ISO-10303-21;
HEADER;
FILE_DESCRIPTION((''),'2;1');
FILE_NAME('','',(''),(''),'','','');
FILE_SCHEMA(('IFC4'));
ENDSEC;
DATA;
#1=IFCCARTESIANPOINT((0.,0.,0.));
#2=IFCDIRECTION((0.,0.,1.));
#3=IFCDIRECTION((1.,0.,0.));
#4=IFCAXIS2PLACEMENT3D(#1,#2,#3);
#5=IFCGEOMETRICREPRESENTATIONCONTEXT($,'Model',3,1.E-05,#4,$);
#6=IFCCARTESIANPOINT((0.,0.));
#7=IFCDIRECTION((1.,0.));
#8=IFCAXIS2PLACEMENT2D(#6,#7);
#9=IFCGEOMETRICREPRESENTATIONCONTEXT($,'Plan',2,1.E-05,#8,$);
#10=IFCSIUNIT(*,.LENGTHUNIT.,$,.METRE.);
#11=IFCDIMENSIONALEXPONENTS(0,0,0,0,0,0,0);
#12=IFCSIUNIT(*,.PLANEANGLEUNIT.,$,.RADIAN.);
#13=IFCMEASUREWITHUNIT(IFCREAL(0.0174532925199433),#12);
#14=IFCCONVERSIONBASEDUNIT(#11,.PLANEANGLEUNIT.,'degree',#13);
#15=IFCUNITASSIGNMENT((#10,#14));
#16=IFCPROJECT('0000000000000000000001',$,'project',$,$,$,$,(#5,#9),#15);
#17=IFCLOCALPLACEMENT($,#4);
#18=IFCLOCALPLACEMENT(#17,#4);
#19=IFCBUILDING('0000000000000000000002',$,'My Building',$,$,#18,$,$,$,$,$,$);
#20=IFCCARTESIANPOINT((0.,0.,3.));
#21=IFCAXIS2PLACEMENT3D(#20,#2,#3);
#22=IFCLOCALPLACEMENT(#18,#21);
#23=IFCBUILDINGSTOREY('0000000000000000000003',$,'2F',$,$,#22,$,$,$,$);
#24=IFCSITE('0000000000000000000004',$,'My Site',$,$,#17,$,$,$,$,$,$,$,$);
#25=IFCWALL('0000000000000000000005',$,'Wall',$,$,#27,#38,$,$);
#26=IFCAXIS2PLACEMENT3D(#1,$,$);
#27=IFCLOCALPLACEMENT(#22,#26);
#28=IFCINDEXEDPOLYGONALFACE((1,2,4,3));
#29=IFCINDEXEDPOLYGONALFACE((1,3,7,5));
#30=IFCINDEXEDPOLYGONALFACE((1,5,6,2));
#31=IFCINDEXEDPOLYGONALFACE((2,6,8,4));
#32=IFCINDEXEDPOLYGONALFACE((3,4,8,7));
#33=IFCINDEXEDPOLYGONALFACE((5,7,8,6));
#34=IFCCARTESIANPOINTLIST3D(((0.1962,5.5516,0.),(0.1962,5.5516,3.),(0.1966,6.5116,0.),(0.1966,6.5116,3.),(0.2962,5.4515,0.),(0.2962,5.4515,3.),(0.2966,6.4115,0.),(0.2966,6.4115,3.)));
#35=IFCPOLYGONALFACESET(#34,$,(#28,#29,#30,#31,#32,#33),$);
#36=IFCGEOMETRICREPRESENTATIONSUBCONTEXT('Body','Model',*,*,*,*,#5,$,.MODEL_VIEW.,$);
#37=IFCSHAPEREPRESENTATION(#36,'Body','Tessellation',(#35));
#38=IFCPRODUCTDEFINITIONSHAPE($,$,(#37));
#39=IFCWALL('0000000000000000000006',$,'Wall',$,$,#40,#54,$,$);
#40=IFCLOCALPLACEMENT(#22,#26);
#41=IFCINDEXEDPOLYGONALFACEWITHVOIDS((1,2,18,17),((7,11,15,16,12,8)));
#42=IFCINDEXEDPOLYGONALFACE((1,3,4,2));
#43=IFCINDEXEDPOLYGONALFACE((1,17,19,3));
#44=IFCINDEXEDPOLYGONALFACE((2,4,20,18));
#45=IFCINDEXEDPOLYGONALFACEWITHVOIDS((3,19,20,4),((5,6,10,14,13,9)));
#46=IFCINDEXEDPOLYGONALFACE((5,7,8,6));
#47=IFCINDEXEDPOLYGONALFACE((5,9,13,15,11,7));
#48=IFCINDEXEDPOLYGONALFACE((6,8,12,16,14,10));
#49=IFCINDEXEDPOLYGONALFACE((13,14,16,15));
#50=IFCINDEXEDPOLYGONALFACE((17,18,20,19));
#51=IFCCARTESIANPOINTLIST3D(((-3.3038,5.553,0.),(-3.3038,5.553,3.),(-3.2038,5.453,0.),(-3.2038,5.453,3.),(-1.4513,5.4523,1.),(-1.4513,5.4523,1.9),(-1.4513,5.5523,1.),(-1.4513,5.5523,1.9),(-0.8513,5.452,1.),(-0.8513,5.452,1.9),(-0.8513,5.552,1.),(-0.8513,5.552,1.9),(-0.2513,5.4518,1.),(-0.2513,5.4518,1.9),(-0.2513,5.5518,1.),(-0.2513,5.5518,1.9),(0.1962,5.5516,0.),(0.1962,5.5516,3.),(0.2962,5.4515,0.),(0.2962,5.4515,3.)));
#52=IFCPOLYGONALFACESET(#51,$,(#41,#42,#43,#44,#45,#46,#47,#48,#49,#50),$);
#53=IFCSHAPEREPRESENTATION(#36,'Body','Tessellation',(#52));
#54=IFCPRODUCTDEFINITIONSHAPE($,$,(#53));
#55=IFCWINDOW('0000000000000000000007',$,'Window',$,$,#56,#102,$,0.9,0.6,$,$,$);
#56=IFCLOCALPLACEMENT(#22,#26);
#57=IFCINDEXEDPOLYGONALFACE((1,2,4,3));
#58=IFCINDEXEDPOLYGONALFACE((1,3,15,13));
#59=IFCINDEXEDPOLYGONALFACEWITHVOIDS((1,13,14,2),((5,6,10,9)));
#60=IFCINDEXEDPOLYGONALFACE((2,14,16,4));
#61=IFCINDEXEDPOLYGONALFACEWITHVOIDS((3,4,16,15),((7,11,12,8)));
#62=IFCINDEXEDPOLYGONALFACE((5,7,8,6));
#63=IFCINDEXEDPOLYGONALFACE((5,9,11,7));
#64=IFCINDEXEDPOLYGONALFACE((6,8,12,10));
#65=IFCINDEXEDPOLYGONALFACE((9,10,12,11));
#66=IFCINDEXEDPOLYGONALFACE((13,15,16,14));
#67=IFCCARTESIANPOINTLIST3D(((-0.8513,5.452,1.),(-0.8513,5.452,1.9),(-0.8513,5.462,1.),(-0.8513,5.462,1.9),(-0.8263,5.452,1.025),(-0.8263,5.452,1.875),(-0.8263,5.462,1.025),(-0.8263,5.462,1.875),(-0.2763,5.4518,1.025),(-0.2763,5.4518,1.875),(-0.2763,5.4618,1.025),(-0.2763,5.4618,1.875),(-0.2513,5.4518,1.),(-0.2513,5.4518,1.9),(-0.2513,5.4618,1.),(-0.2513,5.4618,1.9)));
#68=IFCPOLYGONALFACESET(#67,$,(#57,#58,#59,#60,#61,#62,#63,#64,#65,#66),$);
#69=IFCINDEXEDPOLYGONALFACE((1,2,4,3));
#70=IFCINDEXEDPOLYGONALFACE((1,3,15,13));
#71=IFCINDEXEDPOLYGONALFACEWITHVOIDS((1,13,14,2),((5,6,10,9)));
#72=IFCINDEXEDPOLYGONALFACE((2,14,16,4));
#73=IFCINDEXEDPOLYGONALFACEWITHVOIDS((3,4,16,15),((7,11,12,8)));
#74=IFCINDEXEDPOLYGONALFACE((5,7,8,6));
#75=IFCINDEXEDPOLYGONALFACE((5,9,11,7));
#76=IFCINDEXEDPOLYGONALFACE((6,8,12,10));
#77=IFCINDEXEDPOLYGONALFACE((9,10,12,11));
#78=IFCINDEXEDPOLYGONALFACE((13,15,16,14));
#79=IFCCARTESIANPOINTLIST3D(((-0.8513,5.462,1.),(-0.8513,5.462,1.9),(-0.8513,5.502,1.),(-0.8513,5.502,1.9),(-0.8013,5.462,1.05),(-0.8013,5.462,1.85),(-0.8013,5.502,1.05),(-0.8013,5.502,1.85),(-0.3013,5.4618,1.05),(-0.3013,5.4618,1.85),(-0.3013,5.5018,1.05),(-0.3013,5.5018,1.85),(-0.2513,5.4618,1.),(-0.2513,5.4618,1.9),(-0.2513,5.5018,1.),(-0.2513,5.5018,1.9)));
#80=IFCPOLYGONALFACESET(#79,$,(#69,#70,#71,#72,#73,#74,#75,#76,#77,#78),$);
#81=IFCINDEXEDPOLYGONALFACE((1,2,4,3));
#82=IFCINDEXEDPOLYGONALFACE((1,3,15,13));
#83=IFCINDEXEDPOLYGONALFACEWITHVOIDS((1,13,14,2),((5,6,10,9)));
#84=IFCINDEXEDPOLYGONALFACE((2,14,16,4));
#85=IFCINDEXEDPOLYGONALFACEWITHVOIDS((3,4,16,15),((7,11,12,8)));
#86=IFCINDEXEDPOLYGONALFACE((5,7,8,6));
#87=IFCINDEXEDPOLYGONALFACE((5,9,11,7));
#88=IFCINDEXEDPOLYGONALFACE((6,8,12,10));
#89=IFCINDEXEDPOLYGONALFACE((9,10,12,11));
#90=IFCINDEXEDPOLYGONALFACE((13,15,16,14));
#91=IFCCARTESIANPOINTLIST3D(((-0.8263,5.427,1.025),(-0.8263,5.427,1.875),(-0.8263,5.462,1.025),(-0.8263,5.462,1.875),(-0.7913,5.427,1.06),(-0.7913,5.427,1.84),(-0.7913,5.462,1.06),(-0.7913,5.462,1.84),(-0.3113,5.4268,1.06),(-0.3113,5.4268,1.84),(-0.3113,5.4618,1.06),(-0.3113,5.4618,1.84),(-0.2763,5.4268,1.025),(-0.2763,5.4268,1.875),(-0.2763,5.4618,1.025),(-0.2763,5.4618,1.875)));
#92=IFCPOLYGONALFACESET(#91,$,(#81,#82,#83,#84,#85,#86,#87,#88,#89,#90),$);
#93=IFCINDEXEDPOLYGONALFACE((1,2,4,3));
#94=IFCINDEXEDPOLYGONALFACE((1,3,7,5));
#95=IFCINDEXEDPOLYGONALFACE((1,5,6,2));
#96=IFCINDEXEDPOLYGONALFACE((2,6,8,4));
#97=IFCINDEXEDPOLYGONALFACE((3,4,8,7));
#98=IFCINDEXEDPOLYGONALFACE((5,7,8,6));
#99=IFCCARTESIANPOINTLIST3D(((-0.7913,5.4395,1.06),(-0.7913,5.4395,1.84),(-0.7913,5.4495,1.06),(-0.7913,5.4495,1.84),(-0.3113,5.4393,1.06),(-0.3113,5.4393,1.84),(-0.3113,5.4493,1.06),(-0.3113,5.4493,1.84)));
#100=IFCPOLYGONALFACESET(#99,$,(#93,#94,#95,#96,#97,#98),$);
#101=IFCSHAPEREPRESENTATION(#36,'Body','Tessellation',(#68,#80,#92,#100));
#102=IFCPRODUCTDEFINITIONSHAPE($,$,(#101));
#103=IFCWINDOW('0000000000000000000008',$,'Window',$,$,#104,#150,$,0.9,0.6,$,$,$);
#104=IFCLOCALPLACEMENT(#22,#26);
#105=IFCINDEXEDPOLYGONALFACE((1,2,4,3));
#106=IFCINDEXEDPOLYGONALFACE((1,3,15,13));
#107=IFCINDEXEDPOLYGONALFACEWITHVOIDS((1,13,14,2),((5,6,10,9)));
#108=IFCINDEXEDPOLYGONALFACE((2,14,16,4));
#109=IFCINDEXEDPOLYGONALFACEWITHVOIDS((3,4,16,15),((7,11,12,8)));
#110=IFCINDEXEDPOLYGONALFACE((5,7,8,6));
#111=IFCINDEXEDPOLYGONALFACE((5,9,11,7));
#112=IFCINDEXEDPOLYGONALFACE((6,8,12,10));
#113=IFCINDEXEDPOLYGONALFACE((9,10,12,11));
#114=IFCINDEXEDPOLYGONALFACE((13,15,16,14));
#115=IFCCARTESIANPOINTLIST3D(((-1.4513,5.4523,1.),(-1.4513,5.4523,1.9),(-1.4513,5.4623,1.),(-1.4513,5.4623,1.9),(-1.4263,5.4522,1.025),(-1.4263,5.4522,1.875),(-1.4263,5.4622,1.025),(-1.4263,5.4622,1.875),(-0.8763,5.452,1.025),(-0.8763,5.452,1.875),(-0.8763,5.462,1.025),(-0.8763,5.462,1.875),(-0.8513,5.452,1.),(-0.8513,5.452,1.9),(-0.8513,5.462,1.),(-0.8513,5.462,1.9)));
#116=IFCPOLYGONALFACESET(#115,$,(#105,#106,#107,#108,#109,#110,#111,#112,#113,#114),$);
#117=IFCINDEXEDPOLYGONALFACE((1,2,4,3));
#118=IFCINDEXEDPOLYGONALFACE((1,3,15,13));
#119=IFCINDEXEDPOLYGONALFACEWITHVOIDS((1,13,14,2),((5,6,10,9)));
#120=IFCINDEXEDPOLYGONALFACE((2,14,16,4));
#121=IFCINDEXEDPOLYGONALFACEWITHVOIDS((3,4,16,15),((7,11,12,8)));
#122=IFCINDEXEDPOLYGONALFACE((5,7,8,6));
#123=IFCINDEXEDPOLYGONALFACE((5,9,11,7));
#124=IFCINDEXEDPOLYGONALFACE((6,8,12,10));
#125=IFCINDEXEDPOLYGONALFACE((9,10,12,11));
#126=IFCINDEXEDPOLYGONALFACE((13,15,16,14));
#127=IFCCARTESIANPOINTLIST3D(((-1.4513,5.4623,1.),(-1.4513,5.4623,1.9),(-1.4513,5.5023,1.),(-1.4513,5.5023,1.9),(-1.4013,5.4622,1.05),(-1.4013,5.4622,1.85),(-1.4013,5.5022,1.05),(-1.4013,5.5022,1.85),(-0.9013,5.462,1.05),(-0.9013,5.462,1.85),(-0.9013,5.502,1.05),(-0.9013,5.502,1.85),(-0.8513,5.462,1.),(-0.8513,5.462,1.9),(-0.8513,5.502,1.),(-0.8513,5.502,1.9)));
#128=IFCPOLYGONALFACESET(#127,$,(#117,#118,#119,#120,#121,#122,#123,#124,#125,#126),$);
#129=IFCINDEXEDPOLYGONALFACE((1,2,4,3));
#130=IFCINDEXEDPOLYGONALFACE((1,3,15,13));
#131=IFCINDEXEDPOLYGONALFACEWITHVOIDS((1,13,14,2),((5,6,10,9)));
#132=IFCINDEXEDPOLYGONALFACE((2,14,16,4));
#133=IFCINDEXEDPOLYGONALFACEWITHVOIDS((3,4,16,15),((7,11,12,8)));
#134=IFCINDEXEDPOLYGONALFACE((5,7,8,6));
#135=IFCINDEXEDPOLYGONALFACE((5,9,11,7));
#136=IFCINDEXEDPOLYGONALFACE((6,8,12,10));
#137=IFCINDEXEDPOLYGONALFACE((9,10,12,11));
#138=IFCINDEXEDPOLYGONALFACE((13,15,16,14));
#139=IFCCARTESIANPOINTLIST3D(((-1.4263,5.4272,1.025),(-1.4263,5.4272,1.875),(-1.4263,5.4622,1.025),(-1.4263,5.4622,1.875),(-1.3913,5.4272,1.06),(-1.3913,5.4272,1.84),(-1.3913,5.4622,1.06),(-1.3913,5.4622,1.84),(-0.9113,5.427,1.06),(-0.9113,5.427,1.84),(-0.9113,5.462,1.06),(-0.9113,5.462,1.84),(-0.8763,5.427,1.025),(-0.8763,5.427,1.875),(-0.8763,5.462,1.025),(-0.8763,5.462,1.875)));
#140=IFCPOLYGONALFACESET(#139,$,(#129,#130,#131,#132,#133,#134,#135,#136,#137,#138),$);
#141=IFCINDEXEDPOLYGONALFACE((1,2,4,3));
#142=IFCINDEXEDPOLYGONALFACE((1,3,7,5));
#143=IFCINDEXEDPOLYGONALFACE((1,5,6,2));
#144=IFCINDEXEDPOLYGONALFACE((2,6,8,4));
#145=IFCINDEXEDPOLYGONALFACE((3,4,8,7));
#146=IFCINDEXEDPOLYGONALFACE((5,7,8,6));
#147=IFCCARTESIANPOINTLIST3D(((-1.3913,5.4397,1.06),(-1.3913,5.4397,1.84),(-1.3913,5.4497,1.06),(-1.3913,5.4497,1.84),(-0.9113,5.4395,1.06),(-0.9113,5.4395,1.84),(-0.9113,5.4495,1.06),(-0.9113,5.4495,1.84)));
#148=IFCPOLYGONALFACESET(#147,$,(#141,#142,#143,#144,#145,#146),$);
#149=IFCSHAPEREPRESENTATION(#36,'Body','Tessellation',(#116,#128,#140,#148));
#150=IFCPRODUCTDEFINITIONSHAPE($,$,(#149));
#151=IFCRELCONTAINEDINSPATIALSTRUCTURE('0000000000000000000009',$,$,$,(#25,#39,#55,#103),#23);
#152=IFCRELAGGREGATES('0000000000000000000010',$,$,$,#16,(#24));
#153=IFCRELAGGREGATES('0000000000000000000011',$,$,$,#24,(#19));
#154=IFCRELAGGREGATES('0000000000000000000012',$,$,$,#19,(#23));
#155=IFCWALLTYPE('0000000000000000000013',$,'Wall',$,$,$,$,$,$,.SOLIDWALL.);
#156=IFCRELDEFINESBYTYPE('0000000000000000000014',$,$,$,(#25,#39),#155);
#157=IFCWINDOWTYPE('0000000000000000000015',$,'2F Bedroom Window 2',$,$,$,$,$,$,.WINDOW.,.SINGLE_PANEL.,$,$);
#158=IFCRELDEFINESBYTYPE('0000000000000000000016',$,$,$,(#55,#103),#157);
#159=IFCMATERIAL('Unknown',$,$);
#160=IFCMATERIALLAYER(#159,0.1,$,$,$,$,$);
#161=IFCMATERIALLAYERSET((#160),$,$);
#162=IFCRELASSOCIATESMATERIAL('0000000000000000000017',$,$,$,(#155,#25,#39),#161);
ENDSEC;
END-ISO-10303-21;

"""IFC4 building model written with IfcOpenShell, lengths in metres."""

from ifc_helpers import new_model, entity, si_unit, converted_unit, frame, origin_with_axes, origin_2d_with_axis, place, context, subcontext, project, spatial, line, indexed_curve, outline, extrude, shape, source, transform, mapped, material, layer, layer_set, layer_usage, type_object, type_shapes, element, fill, save


model = new_model("IFC4")

# Units and contexts
model_context = context("Model", 3, precision=1e-05, world=origin_with_axes())
plan_context = context("Plan", 2, precision=1e-05, world=origin_2d_with_axis())
body_context_1 = subcontext(model_context, "Body", "Model", "MODEL_VIEW")
body_context_2 = subcontext(plan_context, "Body", "Plan", "PLAN_VIEW")
ifc_project = project(units=[si_unit("LENGTHUNIT", "METRE"), converted_unit("PLANEANGLEUNIT", "degree", entity("IfcReal", 0.0174532925199433), si_unit("PLANEANGLEUNIT", "RADIAN"), dimensions=[0, 0, 0, 0, 0, 0, 0])], contexts=[model_context, plan_context])

# Site, building, storey
site_placement = place(None, origin_with_axes())
site = spatial("IfcSite", under=ifc_project, at=site_placement, Name="My Site")
building_placement = place(site_placement, origin_with_axes())
building = spatial("IfcBuilding", under=site, at=building_placement, Name="My Building")
storey_placement = place(building_placement, frame((0.0, 0.0, 3.0), z_axis=(0.0, 0.0, 1.0), x_axis=(1.0, 0.0, 0.0)))
storey = spatial("IfcBuildingStorey", under=building, at=storey_placement, Name="2F")

# Shared definitions
ifc_material = material(Name="Unknown")

# Wall
ifc_layer = layer(ifc_material, 0.1)
ifc_layer_set = layer_set([ifc_layer])
wall_type = type_object("IfcWallType", Name="Wall", PredefinedType="SOLIDWALL", material=ifc_layer_set)
ifc_layer_usage_1 = layer_usage(ifc_layer_set, "AXIS2", "POSITIVE", 0.0)
wall_1_placement = place(storey_placement, frame((0.1966, 6.5116, 0.0), z_axis=(0.0, 0.0, 1.0), x_axis=(-0.000415, -1.0, 0.0)))
element("IfcWall", 1, at=wall_1_placement, inside=storey, type_object=wall_type, material=ifc_layer_usage_1, Name="Wall", context=body_context_1, shape_type="SweptSolid", body=[
    extrude(outline(indexed_curve([(0.0, 0.0), (0.1, 0.1), (1.06, 0.1), (0.96, 0.0)], segments=[line(1, 2, 3, 4, 1)])), origin_with_axes(), (0.0, 0.0, 1.0), 3.0),
])

# Wall, openings, windows
ifc_layer_usage_2 = layer_usage(ifc_layer_set, "AXIS2", "POSITIVE", 0.0)
wall_2_placement = place(storey_placement, frame((0.1962, 5.5516, 0.0), z_axis=(0.0, 0.0, 1.0), x_axis=(-1.0, 0.000416, 0.0)))
wall_2 = element("IfcWall", 2, at=wall_2_placement, inside=storey, type_object=wall_type, material=ifc_layer_usage_2, Name="Wall", context=body_context_1, shape_type="SweptSolid", body=[
    extrude(outline(indexed_curve([(0.0, 0.0), (-0.1, 0.1), (3.4, 0.1), (3.5, 0.0)], segments=[line(1, 2, 3, 4, 1)])), origin_with_axes(), (0.0, 0.0, 1.0), 3.0),
])
shared_shape_1 = source(origin_with_axes(), body_context_1, "Body", "SweptSolid", [
    extrude(outline(indexed_curve([(0.0, 0.0), (0.6, 0.0), (0.6, 0.9), (0.0, 0.9)], segments=[line(1, 2, 3, 4, 1)])), frame((0.0, -0.6, 0.0), z_axis=(0.0, -1.0, 0.0), x_axis=(1.0, 0.0, 0.0)), (0.0, 0.0, -1.0), 1.2),
])
opening_1_placement = place(wall_2_placement, frame((0.4475, 0.0, 1.0), z_axis=(0.0, 0.0, 1.0), x_axis=(1.0, 0.0, 0.0)))
opening_1 = element("IfcOpeningElement", 3, at=opening_1_placement, cuts=wall_2, PredefinedType="OPENING", context=body_context_1, shape_type="MappedRepresentation", body=[
    mapped(shared_shape_1, transform((0.0, 0.0, 0.0), x_axis=(1.0, 0.0, 0.0), y_axis=(0.0, 1.0, 0.0), z_axis=(0.0, 0.0, 1.0), scale=1.0)),
])
opening_2_placement = place(wall_2_placement, frame((1.0475, 0.0, 1.0), z_axis=(0.0, 0.0, 1.0), x_axis=(1.0, 0.0, 0.0)))
opening_2 = element("IfcOpeningElement", 4, at=opening_2_placement, cuts=wall_2, PredefinedType="OPENING", context=body_context_1, shape_type="MappedRepresentation", body=[
    mapped(shared_shape_1, transform((0.0, 0.0, 0.0), x_axis=(1.0, 0.0, 0.0), y_axis=(0.0, 1.0, 0.0), z_axis=(0.0, 0.0, 1.0), scale=1.0)),
])
window_type_1 = type_object("IfcWindowType", Name="2F Bedroom Window 2", PartitioningType="SINGLE_PANEL", PredefinedType="WINDOW")
shared_shape_2 = source(origin_with_axes(), body_context_1, "Body", "SweptSolid", [
    extrude(outline(indexed_curve([(0.0, 0.0), (0.6, 0.0), (0.6, 0.9), (0.0, 0.9)], segments=[line(1, 2, 3, 4, 1)]), holes=[indexed_curve([(0.025, 0.025), (0.575, 0.025), (0.575, 0.875), (0.025, 0.875)], segments=[line(1, 2, 3, 4, 1)])]), frame((0.0, 0.09, 0.0), z_axis=(0.0, -1.0, 0.0), x_axis=(1.0, 0.0, 0.0)), (0.0, 0.0, -1.0), 0.01),
    extrude(outline(indexed_curve([(0.0, 0.0), (0.6, 0.0), (0.6, 0.9), (0.0, 0.9)], segments=[line(1, 2, 3, 4, 1)]), holes=[indexed_curve([(0.05, 0.05), (0.55, 0.05), (0.55, 0.85), (0.05, 0.85)], segments=[line(1, 2, 3, 4, 1)])]), frame((0.0, 0.05, 0.0), z_axis=(0.0, -1.0, 0.0), x_axis=(1.0, 0.0, 0.0)), (0.0, 0.0, -1.0), 0.04),
    extrude(outline(indexed_curve([(0.0, 0.0), (0.55, 0.0), (0.55, 0.85), (0.0, 0.85)], segments=[line(1, 2, 3, 4, 1)]), holes=[indexed_curve([(0.035, 0.035), (0.515, 0.035), (0.515, 0.815), (0.035, 0.815)], segments=[line(1, 2, 3, 4, 1)])]), frame((0.025, 0.09, 0.025), z_axis=(0.0, -1.0, 0.0), x_axis=(1.0, 0.0, 0.0)), (0.0, 0.0, -1.0), 0.035),
    extrude(outline(indexed_curve([(0.035, 0.035), (0.515, 0.035), (0.515, 0.815), (0.035, 0.815)], segments=[line(1, 2, 3, 4, 1)])), frame((0.025, 0.1025, 0.025), z_axis=(0.0, -1.0, 0.0), x_axis=(1.0, 0.0, 0.0)), (0.0, 0.0, -1.0), 0.01),
])
shared_shape_3 = source(origin_with_axes(), body_context_2, "Body", "Curve2D", [
    entity("IfcIndexedPolyCurve", entity("IfcCartesianPointList2D", [[0.05, 0.05], [0.55, 0.05]])),
    entity("IfcIndexedPolyCurve", entity("IfcCartesianPointList2D", [[0.0, 0.1], [0.025, 0.1], [0.025, 0.09], [0.05, 0.09], [0.05, 0.05], [0.0, 0.05]]), [entity("IfcLineIndex", [1, 2, 3, 4, 5, 6, 1])]),
    entity("IfcIndexedPolyCurve", entity("IfcCartesianPointList2D", [[0.6, 0.1], [0.575, 0.1], [0.575, 0.09], [0.55, 0.09], [0.55, 0.05], [0.6, 0.05]]), [entity("IfcLineIndex", [1, 2, 3, 4, 5, 6, 1])]),
    entity("IfcIndexedPolyCurve", entity("IfcCartesianPointList2D", [[0.025, 0.09], [0.06, 0.09], [0.06, 0.125], [0.025, 0.125]]), [entity("IfcLineIndex", [1, 2, 3, 4, 1])]),
    entity("IfcIndexedPolyCurve", entity("IfcCartesianPointList2D", [[0.575, 0.09], [0.54, 0.09], [0.54, 0.125], [0.575, 0.125]]), [entity("IfcLineIndex", [1, 2, 3, 4, 1])]),
    entity("IfcIndexedPolyCurve", entity("IfcCartesianPointList2D", [[0.06, 0.09], [0.54, 0.09]])),
    entity("IfcIndexedPolyCurve", entity("IfcCartesianPointList2D", [[0.06, 0.125], [0.54, 0.125]])),
    entity("IfcIndexedPolyCurve", entity("IfcCartesianPointList2D", [[0.06, 0.1075], [0.54, 0.1075]])),
])
type_shapes(window_type_1, [shared_shape_2, shared_shape_3])
window_1_placement = place(opening_1_placement, frame((0.0, 0.0, 0.0), z_axis=(0.0, 0.0, 1.0), x_axis=(1.0, 0.0, 0.0)))
window_1 = element("IfcWindow", 5, at=window_1_placement, inside=storey, type_object=window_type_1, Name="Window", OverallHeight=0.9, OverallWidth=0.6, shapes=[
    shape(body_context_1, "Body", "MappedRepresentation", [mapped(shared_shape_2, transform((0.0, 0.0, 0.0), x_axis=(1.0, 0.0, 0.0), y_axis=(0.0, 1.0, 0.0), z_axis=(0.0, 0.0, 1.0), scale=1.0))]),
    shape(body_context_2, "Body", "MappedRepresentation", [mapped(shared_shape_3, transform((0.0, 0.0, 0.0), x_axis=(1.0, 0.0, 0.0), y_axis=(0.0, 1.0, 0.0), z_axis=(0.0, 0.0, 1.0), scale=1.0))]),
])
fill(opening_1, window_1)
window_2_placement = place(opening_2_placement, origin_with_axes())
window_2 = element("IfcWindow", 6, at=window_2_placement, inside=storey, type_object=window_type_1, Name="Window", OverallHeight=0.9, OverallWidth=0.6, shapes=[
    shape(body_context_1, "Body", "MappedRepresentation", [mapped(shared_shape_2, transform((0.0, 0.0, 0.0), x_axis=(1.0, 0.0, 0.0), y_axis=(0.0, 1.0, 0.0), z_axis=(0.0, 0.0, 1.0), scale=1.0))]),
    shape(body_context_2, "Body", "MappedRepresentation", [mapped(shared_shape_3, transform((0.0, 0.0, 0.0), x_axis=(1.0, 0.0, 0.0), y_axis=(0.0, 1.0, 0.0), z_axis=(0.0, 0.0, 1.0), scale=1.0))]),
])
fill(opening_2, window_2)

save(model, "model.ifc")
